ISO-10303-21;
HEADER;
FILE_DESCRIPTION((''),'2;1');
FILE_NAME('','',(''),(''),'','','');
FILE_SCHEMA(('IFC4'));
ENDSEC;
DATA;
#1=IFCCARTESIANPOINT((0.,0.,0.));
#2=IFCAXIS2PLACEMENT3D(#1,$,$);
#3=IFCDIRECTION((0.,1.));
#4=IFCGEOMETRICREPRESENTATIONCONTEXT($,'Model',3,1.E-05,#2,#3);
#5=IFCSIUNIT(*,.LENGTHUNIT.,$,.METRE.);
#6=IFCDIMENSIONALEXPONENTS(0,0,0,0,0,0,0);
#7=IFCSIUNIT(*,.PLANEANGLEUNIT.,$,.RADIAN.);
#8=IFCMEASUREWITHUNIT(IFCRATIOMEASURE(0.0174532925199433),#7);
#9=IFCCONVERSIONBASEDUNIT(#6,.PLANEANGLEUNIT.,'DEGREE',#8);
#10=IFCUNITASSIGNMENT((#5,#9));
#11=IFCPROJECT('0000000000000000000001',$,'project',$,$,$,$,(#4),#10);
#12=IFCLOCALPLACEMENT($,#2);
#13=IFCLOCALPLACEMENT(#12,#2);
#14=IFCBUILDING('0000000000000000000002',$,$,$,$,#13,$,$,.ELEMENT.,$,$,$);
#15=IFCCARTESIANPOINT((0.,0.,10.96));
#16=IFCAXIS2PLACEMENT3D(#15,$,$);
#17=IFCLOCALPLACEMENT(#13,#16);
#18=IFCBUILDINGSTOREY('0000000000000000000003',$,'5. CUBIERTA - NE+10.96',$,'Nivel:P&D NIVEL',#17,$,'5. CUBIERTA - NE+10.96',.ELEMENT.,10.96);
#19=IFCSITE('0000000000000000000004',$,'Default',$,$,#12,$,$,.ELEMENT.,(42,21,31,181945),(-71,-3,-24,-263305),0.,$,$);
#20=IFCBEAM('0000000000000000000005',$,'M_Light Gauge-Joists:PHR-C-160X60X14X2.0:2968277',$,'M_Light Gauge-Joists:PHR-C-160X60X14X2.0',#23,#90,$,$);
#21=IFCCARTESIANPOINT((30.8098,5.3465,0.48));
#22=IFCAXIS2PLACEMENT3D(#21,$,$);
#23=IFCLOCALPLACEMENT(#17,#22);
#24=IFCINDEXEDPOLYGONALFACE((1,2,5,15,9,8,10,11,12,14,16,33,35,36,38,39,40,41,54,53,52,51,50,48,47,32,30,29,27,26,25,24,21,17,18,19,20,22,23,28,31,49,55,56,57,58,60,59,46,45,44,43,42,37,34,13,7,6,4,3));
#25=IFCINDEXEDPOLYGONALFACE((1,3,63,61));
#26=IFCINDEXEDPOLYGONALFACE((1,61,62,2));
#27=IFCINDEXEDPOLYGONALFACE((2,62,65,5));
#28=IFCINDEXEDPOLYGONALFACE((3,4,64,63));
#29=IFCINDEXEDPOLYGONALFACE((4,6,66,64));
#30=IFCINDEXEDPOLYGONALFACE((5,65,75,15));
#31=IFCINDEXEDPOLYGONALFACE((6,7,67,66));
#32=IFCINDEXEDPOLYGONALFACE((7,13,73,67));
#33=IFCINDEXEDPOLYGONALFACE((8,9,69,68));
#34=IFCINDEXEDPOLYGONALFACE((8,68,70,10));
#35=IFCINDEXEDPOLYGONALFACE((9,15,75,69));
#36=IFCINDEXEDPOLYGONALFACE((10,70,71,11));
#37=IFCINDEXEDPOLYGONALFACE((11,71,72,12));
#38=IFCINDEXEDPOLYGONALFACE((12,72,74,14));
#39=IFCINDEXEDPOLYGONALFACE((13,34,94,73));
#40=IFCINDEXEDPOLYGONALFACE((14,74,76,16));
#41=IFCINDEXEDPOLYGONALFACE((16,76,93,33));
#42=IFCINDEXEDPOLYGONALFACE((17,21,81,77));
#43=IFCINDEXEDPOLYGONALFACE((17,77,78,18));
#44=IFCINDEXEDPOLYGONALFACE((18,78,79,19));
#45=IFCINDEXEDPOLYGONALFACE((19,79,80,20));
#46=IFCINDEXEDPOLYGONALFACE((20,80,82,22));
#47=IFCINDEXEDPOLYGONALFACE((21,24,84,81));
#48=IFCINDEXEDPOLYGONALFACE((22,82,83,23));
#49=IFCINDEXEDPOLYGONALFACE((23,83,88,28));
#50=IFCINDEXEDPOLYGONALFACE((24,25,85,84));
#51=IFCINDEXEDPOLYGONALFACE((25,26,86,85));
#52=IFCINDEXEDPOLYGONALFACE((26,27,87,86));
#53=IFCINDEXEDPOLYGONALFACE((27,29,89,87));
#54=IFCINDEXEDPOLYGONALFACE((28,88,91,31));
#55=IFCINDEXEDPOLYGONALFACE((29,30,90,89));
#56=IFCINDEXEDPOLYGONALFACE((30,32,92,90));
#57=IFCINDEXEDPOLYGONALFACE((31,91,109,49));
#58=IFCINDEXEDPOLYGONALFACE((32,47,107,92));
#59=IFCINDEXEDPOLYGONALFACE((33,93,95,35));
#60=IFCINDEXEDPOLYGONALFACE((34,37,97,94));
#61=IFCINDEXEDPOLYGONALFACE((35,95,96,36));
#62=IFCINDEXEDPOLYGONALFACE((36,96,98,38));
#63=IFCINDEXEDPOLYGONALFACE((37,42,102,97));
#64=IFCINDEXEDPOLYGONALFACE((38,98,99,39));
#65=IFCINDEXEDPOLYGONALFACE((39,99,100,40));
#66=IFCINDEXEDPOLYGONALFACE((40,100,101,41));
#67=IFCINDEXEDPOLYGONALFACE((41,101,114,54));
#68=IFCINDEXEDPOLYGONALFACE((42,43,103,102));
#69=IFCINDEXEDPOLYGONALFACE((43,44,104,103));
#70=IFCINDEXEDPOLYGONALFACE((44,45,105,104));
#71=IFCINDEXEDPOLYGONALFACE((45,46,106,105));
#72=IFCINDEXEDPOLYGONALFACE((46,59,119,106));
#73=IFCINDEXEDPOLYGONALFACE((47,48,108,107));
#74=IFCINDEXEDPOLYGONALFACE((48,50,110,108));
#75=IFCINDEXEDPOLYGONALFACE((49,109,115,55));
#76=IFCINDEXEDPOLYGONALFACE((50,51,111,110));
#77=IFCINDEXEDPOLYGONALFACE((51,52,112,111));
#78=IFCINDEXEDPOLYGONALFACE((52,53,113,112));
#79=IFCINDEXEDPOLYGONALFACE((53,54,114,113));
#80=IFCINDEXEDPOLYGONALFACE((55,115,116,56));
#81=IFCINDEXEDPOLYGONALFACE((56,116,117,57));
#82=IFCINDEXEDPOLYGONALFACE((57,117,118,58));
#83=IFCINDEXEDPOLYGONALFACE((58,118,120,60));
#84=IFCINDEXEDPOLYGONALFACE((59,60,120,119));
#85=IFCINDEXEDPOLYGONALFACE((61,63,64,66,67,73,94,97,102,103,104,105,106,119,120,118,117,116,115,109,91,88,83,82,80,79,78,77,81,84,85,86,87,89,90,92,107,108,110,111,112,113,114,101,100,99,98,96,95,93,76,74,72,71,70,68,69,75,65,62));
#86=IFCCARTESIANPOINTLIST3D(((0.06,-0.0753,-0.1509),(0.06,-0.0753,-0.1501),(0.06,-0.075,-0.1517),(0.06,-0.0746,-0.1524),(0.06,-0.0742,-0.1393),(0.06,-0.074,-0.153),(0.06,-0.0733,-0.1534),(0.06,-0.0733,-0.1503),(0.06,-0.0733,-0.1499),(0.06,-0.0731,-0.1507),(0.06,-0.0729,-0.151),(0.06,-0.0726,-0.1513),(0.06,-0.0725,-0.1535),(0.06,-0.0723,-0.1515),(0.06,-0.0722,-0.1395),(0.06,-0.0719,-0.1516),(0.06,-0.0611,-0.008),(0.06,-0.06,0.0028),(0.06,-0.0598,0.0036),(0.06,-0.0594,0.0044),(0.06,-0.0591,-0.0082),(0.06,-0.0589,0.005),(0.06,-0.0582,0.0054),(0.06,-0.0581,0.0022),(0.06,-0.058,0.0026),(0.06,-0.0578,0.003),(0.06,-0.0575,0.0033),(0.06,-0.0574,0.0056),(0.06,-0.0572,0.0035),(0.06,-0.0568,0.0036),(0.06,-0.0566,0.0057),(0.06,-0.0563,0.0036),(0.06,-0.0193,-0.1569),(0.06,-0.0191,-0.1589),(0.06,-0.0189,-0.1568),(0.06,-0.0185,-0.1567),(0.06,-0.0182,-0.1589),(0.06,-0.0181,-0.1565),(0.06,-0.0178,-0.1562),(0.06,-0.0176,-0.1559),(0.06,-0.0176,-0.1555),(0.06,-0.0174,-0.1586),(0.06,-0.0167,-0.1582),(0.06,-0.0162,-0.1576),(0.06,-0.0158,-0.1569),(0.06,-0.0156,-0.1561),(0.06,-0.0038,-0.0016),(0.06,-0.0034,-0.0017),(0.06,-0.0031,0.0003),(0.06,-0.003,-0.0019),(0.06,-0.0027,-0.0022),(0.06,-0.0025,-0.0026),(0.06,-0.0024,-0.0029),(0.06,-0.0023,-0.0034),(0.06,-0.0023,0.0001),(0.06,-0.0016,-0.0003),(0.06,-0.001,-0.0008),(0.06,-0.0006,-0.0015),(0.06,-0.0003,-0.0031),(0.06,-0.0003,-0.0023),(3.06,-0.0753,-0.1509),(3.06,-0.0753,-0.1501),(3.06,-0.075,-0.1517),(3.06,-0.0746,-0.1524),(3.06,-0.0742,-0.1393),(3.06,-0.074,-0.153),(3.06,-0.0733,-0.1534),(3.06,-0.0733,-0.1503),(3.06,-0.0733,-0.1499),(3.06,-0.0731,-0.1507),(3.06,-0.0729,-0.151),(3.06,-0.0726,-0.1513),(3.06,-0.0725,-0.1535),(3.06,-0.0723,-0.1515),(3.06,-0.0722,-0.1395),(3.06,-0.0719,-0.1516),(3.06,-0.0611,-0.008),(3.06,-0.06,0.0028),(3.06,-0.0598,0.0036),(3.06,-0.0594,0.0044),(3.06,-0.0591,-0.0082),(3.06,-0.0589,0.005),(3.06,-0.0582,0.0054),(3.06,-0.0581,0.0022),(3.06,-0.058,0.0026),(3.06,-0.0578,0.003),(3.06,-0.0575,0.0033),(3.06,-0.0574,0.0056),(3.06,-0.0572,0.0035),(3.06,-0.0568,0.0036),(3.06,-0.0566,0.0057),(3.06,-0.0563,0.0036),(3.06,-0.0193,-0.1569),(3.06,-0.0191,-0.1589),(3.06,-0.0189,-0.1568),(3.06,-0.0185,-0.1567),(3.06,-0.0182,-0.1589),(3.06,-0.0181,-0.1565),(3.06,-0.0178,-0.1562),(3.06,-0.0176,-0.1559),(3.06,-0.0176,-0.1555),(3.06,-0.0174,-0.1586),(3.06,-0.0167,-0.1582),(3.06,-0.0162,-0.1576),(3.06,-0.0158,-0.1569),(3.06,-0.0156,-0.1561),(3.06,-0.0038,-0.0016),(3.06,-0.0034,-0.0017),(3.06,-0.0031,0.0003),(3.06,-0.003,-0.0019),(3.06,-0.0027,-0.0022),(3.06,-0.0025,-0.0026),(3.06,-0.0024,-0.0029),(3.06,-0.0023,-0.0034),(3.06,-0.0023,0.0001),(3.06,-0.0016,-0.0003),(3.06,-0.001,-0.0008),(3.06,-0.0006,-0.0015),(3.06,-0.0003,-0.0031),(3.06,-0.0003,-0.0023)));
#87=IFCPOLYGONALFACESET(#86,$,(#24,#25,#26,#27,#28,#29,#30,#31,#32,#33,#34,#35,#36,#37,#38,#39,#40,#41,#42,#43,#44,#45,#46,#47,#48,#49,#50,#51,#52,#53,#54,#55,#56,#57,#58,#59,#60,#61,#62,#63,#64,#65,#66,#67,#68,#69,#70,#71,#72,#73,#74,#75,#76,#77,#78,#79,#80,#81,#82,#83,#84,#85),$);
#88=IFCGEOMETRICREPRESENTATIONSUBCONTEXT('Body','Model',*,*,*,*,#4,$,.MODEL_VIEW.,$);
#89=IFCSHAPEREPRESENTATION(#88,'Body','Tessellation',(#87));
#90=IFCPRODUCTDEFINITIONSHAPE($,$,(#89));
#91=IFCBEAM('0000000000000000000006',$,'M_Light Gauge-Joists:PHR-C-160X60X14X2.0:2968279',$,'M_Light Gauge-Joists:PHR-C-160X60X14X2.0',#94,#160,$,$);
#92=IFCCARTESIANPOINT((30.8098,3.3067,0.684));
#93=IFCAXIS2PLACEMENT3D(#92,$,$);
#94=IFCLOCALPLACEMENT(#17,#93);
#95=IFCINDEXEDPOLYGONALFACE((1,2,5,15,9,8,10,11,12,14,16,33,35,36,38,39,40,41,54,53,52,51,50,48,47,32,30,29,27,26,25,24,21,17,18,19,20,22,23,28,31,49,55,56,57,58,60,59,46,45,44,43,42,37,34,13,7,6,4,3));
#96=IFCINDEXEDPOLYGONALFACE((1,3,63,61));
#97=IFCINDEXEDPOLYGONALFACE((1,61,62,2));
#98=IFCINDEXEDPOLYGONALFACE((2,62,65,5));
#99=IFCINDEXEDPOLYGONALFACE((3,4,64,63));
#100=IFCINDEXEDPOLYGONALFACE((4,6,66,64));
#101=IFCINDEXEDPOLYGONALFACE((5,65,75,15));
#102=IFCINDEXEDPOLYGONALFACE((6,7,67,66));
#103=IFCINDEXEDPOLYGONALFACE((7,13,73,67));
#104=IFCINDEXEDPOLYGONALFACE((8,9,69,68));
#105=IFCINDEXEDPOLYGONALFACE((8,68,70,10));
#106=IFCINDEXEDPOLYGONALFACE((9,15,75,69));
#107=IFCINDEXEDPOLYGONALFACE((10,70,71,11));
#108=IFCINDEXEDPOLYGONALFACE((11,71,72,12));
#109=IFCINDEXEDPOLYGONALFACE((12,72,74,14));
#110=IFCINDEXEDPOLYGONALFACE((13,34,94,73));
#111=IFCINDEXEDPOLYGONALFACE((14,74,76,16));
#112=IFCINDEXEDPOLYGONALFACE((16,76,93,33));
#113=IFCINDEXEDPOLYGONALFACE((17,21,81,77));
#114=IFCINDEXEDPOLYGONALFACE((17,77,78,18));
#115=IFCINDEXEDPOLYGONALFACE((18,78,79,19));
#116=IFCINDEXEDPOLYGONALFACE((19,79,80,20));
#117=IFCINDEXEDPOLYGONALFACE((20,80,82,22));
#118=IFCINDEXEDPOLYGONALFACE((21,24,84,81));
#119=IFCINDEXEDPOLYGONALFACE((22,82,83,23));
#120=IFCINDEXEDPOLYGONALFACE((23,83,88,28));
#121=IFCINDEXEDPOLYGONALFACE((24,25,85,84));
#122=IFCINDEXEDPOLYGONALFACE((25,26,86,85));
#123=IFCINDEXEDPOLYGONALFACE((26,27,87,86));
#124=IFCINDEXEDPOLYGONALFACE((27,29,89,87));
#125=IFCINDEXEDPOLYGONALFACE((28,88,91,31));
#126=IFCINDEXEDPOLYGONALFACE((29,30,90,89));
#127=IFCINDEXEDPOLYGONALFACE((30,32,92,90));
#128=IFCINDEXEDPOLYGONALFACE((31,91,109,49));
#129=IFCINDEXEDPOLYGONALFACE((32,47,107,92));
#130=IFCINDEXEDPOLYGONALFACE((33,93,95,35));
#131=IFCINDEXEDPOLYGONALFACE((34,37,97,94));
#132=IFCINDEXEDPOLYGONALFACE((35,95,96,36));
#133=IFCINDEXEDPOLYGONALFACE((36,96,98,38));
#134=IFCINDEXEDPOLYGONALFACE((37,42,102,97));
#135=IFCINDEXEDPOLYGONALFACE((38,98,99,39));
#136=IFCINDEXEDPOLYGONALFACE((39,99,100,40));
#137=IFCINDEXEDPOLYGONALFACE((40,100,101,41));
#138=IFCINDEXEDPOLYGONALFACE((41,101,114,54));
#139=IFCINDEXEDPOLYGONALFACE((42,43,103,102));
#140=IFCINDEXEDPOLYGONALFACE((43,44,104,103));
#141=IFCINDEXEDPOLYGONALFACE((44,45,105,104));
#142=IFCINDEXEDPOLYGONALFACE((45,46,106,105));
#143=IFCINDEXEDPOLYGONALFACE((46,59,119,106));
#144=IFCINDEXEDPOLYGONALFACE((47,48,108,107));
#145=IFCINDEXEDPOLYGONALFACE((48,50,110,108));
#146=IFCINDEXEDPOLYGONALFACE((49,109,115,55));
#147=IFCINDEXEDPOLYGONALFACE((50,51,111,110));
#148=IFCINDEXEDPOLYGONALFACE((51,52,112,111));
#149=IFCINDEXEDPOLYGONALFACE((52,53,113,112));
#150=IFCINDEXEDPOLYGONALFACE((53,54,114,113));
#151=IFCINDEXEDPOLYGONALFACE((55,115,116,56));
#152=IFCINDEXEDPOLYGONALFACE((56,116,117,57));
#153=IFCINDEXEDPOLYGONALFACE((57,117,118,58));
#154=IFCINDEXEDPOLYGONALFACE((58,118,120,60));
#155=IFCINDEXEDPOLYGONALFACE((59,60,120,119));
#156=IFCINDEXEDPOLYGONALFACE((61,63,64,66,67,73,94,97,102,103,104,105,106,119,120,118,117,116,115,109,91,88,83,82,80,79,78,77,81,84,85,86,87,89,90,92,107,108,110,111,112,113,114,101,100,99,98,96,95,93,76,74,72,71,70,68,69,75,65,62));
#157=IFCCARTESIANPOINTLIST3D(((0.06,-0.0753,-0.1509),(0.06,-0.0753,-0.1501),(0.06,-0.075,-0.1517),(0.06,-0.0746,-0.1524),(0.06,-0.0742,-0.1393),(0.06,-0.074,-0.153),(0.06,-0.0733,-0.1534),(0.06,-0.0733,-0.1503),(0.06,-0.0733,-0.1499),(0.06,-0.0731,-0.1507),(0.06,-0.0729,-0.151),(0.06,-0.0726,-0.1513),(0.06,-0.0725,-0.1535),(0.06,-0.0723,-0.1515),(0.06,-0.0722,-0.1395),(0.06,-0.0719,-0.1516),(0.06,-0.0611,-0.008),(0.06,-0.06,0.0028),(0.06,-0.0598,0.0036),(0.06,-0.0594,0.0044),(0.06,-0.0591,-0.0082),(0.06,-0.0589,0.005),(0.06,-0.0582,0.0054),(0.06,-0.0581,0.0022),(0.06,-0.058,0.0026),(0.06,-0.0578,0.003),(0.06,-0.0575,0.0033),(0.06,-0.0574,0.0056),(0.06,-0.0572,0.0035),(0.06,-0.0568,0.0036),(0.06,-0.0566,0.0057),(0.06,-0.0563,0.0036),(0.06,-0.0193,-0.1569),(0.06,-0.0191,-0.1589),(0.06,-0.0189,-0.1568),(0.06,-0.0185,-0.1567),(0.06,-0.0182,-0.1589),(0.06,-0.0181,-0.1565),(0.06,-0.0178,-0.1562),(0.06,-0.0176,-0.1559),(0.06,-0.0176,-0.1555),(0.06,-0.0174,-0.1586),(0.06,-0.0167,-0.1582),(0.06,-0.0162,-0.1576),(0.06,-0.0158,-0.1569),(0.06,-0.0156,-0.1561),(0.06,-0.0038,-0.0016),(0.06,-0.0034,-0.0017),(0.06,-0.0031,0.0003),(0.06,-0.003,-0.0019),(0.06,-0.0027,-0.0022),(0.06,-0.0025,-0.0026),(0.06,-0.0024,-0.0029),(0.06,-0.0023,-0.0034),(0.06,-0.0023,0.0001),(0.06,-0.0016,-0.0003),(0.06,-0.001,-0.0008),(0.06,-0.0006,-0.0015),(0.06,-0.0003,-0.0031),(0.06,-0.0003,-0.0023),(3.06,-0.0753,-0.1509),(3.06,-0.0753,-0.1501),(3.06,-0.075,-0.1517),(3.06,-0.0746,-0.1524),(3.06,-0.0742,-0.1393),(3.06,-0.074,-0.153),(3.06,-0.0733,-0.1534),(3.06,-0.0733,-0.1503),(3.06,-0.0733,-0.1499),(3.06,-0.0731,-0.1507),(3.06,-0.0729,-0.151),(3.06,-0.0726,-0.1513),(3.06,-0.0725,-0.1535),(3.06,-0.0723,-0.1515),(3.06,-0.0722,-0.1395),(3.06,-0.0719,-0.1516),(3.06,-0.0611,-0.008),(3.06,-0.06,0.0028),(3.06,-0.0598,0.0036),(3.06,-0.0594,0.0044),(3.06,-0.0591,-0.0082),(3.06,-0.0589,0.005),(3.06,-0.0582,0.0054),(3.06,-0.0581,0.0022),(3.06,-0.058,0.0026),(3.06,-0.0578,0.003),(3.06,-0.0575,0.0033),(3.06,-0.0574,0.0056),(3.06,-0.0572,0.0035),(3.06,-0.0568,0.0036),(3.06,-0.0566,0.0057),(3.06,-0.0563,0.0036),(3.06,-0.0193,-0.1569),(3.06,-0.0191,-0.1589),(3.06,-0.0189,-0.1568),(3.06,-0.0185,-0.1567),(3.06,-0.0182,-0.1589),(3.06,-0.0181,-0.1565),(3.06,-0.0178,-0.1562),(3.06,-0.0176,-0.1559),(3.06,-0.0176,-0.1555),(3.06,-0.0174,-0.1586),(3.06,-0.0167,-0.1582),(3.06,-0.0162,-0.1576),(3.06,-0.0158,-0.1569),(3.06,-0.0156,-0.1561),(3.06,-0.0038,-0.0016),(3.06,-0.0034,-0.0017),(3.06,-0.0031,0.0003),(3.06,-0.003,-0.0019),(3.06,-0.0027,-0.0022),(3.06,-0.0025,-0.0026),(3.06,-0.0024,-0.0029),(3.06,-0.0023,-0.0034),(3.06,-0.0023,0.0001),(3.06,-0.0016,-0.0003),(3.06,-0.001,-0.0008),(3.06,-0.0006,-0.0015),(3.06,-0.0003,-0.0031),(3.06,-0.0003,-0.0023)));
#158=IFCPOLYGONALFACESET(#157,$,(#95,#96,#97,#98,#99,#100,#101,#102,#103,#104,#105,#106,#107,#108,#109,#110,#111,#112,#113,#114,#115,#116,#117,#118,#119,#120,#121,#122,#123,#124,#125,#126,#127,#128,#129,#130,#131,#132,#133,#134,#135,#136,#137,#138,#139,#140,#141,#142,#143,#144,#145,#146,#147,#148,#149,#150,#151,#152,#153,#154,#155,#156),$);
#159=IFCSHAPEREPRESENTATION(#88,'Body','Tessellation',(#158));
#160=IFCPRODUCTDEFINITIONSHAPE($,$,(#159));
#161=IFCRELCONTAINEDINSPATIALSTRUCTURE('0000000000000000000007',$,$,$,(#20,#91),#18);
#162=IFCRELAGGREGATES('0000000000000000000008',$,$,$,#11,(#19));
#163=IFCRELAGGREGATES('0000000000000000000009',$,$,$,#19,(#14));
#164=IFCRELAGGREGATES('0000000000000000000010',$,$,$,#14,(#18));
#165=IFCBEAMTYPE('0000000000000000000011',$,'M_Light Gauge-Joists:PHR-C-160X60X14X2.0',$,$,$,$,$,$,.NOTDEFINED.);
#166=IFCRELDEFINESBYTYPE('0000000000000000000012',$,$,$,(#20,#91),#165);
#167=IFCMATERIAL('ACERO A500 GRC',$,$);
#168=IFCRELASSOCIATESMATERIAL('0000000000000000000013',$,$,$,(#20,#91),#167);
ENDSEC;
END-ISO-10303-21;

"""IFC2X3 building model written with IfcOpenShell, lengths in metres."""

from ifc_helpers import new_model, entity, si_unit, converted_unit, direction, frame, frame_2d, origin, place, context, subcontext, project, spatial, polyline, circle_curve, parameter, trimmed, segment, composite_curve, outline, extrude, material, type_object, element, save


model = new_model("IFC2X3")

# Units and contexts
model_context = context("Model", 3, precision=1e-05, world=origin(), true_north=direction((0.0, 1.0)))
body_context = subcontext(model_context, "Body", "Model", "MODEL_VIEW")
ifc_project = project(units=[si_unit("LENGTHUNIT", "METRE"), converted_unit("PLANEANGLEUNIT", "DEGREE", entity("IfcRatioMeasure", 0.0174532925199433), si_unit("PLANEANGLEUNIT", "RADIAN"), dimensions=[0, 0, 0, 0, 0, 0, 0])], contexts=[model_context])

# Site, building, storey
site_placement = place(None, origin())
site = spatial("IfcSite", under=ifc_project, at=site_placement, Name="Default", CompositionType="ELEMENT", RefLatitude=(42, 21, 31, 181945), RefLongitude=(-71, -3, -24, -263305), RefElevation=0.0)
building_placement = place(site_placement, origin())
building = spatial("IfcBuilding", under=site, at=building_placement, CompositionType="ELEMENT")
storey_placement = place(building_placement, frame((0.0, 0.0, 10.96)))
storey = spatial("IfcBuildingStorey", under=building, at=storey_placement, Name="5. CUBIERTA - NE+10.96", ObjectType="Nivel:P&D NIVEL", LongName="5. CUBIERTA - NE+10.96", CompositionType="ELEMENT", Elevation=10.96)

# Beams
ifc_material_1 = material(Name="ACERO A500 GRC")
beam_type_1 = type_object("IfcBeamType", Name="M_Light Gauge-Joists:PHR-C-160X60X14X2.0", PredefinedType="NOTDEFINED")
beam_1_placement = place(storey_placement, frame((30.8098, 5.3465, 0.48)))
element("IfcBeam", 1, at=beam_1_placement, inside=storey, type_object=beam_type_1, material=ifc_material_1, Name="M_Light Gauge-Joists:PHR-C-160X60X14X2.0:2968277", ObjectType="M_Light Gauge-Joists:PHR-C-160X60X14X2.0", context=body_context, shape_type="SweptSolid", body=[
    extrude(outline(composite_curve([segment(polyline([(-0.0768, -0.0358), (0.0768, -0.0358)]), True, "CONTINUOUS"), segment(trimmed(circle_curve(frame_2d((0.0768, -0.0326), x_axis=(0.0, -1.0)), 0.0032), [parameter(0.0)], [parameter(90.0)], True, "PARAMETER"), True, "CONTINUOUS"), segment(polyline([(0.08, -0.0326), (0.08, 0.021)]), True, "CONTINUOUS"), segment(trimmed(circle_curve(frame_2d((0.0768, 0.021), x_axis=(1.0, 0.0)), 0.0032), [parameter(0.0)], [parameter(90.0)], True, "PARAMETER"), True, "CONTINUOUS"), segment(polyline([(0.0768, 0.0242), (0.066, 0.0242)]), True, "CONTINUOUS"), segment(polyline([(0.066, 0.0242), (0.066, 0.0222)]), True, "CONTINUOUS"), segment(polyline([(0.066, 0.0222), (0.0764, 0.0222)]), True, "CONTINUOUS"), segment(trimmed(circle_curve(frame_2d((0.0764, 0.0206), x_axis=(0.0, 1.0)), 0.0016), [parameter(270.0)], [parameter(0.0)], True, "PARAMETER"), False, "CONTINUOUS"), segment(polyline([(0.078, 0.0206), (0.078, -0.0322)]), True, "CONTINUOUS"), segment(trimmed(circle_curve(frame_2d((0.0764, -0.0322), x_axis=(1.0, 0.0)), 0.0016), [parameter(270.0)], [parameter(0.0)], True, "PARAMETER"), False, "CONTINUOUS"), segment(polyline([(0.0764, -0.0338), (-0.0764, -0.0338)]), True, "CONTINUOUS"), segment(trimmed(circle_curve(frame_2d((-0.0764, -0.0322), x_axis=(0.0, -1.0)), 0.0016), [parameter(270.0)], [parameter(0.0)], True, "PARAMETER"), False, "CONTINUOUS"), segment(polyline([(-0.078, -0.0322), (-0.078, 0.0206)]), True, "CONTINUOUS"), segment(trimmed(circle_curve(frame_2d((-0.0764, 0.0206), x_axis=(-1.0, 0.0)), 0.0016), [parameter(270.0)], [parameter(0.0)], True, "PARAMETER"), False, "CONTINUOUS"), segment(polyline([(-0.0764, 0.0222), (-0.066, 0.0222)]), True, "CONTINUOUS"), segment(polyline([(-0.066, 0.0222), (-0.066, 0.0242)]), True, "CONTINUOUS"), segment(polyline([(-0.066, 0.0242), (-0.0768, 0.0242)]), True, "CONTINUOUS"), segment(trimmed(circle_curve(frame_2d((-0.0768, 0.021), x_axis=(0.0, 1.0)), 0.0032), [parameter(0.0)], [parameter(90.0)], True, "PARAMETER"), True, "CONTINUOUS"), segment(polyline([(-0.08, 0.021), (-0.08, -0.0326)]), True, "CONTINUOUS"), segment(trimmed(circle_curve(frame_2d((-0.0768, -0.0326), x_axis=(-1.0, 0.0)), 0.0032), [parameter(0.0)], [parameter(90.0)], True, "PARAMETER"), True, "CONTINUOUS")], self_intersect=False)), frame((0.06, -0.0436, -0.076), z_axis=(1.0, 0.0, 0.0), x_axis=(0.0, 0.099504, 0.995037)), (0.0, 0.0, 1.0), 3.0),
])
beam_2_placement = place(storey_placement, frame((30.8098, 3.3067, 0.684)))
element("IfcBeam", 2, at=beam_2_placement, inside=storey, type_object=beam_type_1, material=ifc_material_1, Name="M_Light Gauge-Joists:PHR-C-160X60X14X2.0:2968279", ObjectType="M_Light Gauge-Joists:PHR-C-160X60X14X2.0", context=body_context, shape_type="SweptSolid", body=[
    extrude(outline(composite_curve([segment(polyline([(-0.0768, -0.0358), (0.0768, -0.0358)]), True, "CONTINUOUS"), segment(trimmed(circle_curve(frame_2d((0.0768, -0.0326), x_axis=(0.0, -1.0)), 0.0032), [parameter(0.0)], [parameter(90.0)], True, "PARAMETER"), True, "CONTINUOUS"), segment(polyline([(0.08, -0.0326), (0.08, 0.021)]), True, "CONTINUOUS"), segment(trimmed(circle_curve(frame_2d((0.0768, 0.021), x_axis=(1.0, 0.0)), 0.0032), [parameter(0.0)], [parameter(90.0)], True, "PARAMETER"), True, "CONTINUOUS"), segment(polyline([(0.0768, 0.0242), (0.066, 0.0242)]), True, "CONTINUOUS"), segment(polyline([(0.066, 0.0242), (0.066, 0.0222)]), True, "CONTINUOUS"), segment(polyline([(0.066, 0.0222), (0.0764, 0.0222)]), True, "CONTINUOUS"), segment(trimmed(circle_curve(frame_2d((0.0764, 0.0206), x_axis=(0.0, 1.0)), 0.0016), [parameter(270.0)], [parameter(0.0)], True, "PARAMETER"), False, "CONTINUOUS"), segment(polyline([(0.078, 0.0206), (0.078, -0.0322)]), True, "CONTINUOUS"), segment(trimmed(circle_curve(frame_2d((0.0764, -0.0322), x_axis=(1.0, 0.0)), 0.0016), [parameter(270.0)], [parameter(0.0)], True, "PARAMETER"), False, "CONTINUOUS"), segment(polyline([(0.0764, -0.0338), (-0.0764, -0.0338)]), True, "CONTINUOUS"), segment(trimmed(circle_curve(frame_2d((-0.0764, -0.0322), x_axis=(0.0, -1.0)), 0.0016), [parameter(270.0)], [parameter(0.0)], True, "PARAMETER"), False, "CONTINUOUS"), segment(polyline([(-0.078, -0.0322), (-0.078, 0.0206)]), True, "CONTINUOUS"), segment(trimmed(circle_curve(frame_2d((-0.0764, 0.0206), x_axis=(-1.0, 0.0)), 0.0016), [parameter(270.0)], [parameter(0.0)], True, "PARAMETER"), False, "CONTINUOUS"), segment(polyline([(-0.0764, 0.0222), (-0.066, 0.0222)]), True, "CONTINUOUS"), segment(polyline([(-0.066, 0.0222), (-0.066, 0.0242)]), True, "CONTINUOUS"), segment(polyline([(-0.066, 0.0242), (-0.0768, 0.0242)]), True, "CONTINUOUS"), segment(trimmed(circle_curve(frame_2d((-0.0768, 0.021), x_axis=(0.0, 1.0)), 0.0032), [parameter(0.0)], [parameter(90.0)], True, "PARAMETER"), True, "CONTINUOUS"), segment(polyline([(-0.08, 0.021), (-0.08, -0.0326)]), True, "CONTINUOUS"), segment(trimmed(circle_curve(frame_2d((-0.0768, -0.0326), x_axis=(-1.0, 0.0)), 0.0032), [parameter(0.0)], [parameter(90.0)], True, "PARAMETER"), True, "CONTINUOUS")], self_intersect=False)), frame((0.06, -0.0436, -0.076), z_axis=(1.0, 0.0, 0.0), x_axis=(0.0, 0.099504, 0.995037)), (0.0, 0.0, 1.0), 3.0),
])

save(model, "model.ifc")
